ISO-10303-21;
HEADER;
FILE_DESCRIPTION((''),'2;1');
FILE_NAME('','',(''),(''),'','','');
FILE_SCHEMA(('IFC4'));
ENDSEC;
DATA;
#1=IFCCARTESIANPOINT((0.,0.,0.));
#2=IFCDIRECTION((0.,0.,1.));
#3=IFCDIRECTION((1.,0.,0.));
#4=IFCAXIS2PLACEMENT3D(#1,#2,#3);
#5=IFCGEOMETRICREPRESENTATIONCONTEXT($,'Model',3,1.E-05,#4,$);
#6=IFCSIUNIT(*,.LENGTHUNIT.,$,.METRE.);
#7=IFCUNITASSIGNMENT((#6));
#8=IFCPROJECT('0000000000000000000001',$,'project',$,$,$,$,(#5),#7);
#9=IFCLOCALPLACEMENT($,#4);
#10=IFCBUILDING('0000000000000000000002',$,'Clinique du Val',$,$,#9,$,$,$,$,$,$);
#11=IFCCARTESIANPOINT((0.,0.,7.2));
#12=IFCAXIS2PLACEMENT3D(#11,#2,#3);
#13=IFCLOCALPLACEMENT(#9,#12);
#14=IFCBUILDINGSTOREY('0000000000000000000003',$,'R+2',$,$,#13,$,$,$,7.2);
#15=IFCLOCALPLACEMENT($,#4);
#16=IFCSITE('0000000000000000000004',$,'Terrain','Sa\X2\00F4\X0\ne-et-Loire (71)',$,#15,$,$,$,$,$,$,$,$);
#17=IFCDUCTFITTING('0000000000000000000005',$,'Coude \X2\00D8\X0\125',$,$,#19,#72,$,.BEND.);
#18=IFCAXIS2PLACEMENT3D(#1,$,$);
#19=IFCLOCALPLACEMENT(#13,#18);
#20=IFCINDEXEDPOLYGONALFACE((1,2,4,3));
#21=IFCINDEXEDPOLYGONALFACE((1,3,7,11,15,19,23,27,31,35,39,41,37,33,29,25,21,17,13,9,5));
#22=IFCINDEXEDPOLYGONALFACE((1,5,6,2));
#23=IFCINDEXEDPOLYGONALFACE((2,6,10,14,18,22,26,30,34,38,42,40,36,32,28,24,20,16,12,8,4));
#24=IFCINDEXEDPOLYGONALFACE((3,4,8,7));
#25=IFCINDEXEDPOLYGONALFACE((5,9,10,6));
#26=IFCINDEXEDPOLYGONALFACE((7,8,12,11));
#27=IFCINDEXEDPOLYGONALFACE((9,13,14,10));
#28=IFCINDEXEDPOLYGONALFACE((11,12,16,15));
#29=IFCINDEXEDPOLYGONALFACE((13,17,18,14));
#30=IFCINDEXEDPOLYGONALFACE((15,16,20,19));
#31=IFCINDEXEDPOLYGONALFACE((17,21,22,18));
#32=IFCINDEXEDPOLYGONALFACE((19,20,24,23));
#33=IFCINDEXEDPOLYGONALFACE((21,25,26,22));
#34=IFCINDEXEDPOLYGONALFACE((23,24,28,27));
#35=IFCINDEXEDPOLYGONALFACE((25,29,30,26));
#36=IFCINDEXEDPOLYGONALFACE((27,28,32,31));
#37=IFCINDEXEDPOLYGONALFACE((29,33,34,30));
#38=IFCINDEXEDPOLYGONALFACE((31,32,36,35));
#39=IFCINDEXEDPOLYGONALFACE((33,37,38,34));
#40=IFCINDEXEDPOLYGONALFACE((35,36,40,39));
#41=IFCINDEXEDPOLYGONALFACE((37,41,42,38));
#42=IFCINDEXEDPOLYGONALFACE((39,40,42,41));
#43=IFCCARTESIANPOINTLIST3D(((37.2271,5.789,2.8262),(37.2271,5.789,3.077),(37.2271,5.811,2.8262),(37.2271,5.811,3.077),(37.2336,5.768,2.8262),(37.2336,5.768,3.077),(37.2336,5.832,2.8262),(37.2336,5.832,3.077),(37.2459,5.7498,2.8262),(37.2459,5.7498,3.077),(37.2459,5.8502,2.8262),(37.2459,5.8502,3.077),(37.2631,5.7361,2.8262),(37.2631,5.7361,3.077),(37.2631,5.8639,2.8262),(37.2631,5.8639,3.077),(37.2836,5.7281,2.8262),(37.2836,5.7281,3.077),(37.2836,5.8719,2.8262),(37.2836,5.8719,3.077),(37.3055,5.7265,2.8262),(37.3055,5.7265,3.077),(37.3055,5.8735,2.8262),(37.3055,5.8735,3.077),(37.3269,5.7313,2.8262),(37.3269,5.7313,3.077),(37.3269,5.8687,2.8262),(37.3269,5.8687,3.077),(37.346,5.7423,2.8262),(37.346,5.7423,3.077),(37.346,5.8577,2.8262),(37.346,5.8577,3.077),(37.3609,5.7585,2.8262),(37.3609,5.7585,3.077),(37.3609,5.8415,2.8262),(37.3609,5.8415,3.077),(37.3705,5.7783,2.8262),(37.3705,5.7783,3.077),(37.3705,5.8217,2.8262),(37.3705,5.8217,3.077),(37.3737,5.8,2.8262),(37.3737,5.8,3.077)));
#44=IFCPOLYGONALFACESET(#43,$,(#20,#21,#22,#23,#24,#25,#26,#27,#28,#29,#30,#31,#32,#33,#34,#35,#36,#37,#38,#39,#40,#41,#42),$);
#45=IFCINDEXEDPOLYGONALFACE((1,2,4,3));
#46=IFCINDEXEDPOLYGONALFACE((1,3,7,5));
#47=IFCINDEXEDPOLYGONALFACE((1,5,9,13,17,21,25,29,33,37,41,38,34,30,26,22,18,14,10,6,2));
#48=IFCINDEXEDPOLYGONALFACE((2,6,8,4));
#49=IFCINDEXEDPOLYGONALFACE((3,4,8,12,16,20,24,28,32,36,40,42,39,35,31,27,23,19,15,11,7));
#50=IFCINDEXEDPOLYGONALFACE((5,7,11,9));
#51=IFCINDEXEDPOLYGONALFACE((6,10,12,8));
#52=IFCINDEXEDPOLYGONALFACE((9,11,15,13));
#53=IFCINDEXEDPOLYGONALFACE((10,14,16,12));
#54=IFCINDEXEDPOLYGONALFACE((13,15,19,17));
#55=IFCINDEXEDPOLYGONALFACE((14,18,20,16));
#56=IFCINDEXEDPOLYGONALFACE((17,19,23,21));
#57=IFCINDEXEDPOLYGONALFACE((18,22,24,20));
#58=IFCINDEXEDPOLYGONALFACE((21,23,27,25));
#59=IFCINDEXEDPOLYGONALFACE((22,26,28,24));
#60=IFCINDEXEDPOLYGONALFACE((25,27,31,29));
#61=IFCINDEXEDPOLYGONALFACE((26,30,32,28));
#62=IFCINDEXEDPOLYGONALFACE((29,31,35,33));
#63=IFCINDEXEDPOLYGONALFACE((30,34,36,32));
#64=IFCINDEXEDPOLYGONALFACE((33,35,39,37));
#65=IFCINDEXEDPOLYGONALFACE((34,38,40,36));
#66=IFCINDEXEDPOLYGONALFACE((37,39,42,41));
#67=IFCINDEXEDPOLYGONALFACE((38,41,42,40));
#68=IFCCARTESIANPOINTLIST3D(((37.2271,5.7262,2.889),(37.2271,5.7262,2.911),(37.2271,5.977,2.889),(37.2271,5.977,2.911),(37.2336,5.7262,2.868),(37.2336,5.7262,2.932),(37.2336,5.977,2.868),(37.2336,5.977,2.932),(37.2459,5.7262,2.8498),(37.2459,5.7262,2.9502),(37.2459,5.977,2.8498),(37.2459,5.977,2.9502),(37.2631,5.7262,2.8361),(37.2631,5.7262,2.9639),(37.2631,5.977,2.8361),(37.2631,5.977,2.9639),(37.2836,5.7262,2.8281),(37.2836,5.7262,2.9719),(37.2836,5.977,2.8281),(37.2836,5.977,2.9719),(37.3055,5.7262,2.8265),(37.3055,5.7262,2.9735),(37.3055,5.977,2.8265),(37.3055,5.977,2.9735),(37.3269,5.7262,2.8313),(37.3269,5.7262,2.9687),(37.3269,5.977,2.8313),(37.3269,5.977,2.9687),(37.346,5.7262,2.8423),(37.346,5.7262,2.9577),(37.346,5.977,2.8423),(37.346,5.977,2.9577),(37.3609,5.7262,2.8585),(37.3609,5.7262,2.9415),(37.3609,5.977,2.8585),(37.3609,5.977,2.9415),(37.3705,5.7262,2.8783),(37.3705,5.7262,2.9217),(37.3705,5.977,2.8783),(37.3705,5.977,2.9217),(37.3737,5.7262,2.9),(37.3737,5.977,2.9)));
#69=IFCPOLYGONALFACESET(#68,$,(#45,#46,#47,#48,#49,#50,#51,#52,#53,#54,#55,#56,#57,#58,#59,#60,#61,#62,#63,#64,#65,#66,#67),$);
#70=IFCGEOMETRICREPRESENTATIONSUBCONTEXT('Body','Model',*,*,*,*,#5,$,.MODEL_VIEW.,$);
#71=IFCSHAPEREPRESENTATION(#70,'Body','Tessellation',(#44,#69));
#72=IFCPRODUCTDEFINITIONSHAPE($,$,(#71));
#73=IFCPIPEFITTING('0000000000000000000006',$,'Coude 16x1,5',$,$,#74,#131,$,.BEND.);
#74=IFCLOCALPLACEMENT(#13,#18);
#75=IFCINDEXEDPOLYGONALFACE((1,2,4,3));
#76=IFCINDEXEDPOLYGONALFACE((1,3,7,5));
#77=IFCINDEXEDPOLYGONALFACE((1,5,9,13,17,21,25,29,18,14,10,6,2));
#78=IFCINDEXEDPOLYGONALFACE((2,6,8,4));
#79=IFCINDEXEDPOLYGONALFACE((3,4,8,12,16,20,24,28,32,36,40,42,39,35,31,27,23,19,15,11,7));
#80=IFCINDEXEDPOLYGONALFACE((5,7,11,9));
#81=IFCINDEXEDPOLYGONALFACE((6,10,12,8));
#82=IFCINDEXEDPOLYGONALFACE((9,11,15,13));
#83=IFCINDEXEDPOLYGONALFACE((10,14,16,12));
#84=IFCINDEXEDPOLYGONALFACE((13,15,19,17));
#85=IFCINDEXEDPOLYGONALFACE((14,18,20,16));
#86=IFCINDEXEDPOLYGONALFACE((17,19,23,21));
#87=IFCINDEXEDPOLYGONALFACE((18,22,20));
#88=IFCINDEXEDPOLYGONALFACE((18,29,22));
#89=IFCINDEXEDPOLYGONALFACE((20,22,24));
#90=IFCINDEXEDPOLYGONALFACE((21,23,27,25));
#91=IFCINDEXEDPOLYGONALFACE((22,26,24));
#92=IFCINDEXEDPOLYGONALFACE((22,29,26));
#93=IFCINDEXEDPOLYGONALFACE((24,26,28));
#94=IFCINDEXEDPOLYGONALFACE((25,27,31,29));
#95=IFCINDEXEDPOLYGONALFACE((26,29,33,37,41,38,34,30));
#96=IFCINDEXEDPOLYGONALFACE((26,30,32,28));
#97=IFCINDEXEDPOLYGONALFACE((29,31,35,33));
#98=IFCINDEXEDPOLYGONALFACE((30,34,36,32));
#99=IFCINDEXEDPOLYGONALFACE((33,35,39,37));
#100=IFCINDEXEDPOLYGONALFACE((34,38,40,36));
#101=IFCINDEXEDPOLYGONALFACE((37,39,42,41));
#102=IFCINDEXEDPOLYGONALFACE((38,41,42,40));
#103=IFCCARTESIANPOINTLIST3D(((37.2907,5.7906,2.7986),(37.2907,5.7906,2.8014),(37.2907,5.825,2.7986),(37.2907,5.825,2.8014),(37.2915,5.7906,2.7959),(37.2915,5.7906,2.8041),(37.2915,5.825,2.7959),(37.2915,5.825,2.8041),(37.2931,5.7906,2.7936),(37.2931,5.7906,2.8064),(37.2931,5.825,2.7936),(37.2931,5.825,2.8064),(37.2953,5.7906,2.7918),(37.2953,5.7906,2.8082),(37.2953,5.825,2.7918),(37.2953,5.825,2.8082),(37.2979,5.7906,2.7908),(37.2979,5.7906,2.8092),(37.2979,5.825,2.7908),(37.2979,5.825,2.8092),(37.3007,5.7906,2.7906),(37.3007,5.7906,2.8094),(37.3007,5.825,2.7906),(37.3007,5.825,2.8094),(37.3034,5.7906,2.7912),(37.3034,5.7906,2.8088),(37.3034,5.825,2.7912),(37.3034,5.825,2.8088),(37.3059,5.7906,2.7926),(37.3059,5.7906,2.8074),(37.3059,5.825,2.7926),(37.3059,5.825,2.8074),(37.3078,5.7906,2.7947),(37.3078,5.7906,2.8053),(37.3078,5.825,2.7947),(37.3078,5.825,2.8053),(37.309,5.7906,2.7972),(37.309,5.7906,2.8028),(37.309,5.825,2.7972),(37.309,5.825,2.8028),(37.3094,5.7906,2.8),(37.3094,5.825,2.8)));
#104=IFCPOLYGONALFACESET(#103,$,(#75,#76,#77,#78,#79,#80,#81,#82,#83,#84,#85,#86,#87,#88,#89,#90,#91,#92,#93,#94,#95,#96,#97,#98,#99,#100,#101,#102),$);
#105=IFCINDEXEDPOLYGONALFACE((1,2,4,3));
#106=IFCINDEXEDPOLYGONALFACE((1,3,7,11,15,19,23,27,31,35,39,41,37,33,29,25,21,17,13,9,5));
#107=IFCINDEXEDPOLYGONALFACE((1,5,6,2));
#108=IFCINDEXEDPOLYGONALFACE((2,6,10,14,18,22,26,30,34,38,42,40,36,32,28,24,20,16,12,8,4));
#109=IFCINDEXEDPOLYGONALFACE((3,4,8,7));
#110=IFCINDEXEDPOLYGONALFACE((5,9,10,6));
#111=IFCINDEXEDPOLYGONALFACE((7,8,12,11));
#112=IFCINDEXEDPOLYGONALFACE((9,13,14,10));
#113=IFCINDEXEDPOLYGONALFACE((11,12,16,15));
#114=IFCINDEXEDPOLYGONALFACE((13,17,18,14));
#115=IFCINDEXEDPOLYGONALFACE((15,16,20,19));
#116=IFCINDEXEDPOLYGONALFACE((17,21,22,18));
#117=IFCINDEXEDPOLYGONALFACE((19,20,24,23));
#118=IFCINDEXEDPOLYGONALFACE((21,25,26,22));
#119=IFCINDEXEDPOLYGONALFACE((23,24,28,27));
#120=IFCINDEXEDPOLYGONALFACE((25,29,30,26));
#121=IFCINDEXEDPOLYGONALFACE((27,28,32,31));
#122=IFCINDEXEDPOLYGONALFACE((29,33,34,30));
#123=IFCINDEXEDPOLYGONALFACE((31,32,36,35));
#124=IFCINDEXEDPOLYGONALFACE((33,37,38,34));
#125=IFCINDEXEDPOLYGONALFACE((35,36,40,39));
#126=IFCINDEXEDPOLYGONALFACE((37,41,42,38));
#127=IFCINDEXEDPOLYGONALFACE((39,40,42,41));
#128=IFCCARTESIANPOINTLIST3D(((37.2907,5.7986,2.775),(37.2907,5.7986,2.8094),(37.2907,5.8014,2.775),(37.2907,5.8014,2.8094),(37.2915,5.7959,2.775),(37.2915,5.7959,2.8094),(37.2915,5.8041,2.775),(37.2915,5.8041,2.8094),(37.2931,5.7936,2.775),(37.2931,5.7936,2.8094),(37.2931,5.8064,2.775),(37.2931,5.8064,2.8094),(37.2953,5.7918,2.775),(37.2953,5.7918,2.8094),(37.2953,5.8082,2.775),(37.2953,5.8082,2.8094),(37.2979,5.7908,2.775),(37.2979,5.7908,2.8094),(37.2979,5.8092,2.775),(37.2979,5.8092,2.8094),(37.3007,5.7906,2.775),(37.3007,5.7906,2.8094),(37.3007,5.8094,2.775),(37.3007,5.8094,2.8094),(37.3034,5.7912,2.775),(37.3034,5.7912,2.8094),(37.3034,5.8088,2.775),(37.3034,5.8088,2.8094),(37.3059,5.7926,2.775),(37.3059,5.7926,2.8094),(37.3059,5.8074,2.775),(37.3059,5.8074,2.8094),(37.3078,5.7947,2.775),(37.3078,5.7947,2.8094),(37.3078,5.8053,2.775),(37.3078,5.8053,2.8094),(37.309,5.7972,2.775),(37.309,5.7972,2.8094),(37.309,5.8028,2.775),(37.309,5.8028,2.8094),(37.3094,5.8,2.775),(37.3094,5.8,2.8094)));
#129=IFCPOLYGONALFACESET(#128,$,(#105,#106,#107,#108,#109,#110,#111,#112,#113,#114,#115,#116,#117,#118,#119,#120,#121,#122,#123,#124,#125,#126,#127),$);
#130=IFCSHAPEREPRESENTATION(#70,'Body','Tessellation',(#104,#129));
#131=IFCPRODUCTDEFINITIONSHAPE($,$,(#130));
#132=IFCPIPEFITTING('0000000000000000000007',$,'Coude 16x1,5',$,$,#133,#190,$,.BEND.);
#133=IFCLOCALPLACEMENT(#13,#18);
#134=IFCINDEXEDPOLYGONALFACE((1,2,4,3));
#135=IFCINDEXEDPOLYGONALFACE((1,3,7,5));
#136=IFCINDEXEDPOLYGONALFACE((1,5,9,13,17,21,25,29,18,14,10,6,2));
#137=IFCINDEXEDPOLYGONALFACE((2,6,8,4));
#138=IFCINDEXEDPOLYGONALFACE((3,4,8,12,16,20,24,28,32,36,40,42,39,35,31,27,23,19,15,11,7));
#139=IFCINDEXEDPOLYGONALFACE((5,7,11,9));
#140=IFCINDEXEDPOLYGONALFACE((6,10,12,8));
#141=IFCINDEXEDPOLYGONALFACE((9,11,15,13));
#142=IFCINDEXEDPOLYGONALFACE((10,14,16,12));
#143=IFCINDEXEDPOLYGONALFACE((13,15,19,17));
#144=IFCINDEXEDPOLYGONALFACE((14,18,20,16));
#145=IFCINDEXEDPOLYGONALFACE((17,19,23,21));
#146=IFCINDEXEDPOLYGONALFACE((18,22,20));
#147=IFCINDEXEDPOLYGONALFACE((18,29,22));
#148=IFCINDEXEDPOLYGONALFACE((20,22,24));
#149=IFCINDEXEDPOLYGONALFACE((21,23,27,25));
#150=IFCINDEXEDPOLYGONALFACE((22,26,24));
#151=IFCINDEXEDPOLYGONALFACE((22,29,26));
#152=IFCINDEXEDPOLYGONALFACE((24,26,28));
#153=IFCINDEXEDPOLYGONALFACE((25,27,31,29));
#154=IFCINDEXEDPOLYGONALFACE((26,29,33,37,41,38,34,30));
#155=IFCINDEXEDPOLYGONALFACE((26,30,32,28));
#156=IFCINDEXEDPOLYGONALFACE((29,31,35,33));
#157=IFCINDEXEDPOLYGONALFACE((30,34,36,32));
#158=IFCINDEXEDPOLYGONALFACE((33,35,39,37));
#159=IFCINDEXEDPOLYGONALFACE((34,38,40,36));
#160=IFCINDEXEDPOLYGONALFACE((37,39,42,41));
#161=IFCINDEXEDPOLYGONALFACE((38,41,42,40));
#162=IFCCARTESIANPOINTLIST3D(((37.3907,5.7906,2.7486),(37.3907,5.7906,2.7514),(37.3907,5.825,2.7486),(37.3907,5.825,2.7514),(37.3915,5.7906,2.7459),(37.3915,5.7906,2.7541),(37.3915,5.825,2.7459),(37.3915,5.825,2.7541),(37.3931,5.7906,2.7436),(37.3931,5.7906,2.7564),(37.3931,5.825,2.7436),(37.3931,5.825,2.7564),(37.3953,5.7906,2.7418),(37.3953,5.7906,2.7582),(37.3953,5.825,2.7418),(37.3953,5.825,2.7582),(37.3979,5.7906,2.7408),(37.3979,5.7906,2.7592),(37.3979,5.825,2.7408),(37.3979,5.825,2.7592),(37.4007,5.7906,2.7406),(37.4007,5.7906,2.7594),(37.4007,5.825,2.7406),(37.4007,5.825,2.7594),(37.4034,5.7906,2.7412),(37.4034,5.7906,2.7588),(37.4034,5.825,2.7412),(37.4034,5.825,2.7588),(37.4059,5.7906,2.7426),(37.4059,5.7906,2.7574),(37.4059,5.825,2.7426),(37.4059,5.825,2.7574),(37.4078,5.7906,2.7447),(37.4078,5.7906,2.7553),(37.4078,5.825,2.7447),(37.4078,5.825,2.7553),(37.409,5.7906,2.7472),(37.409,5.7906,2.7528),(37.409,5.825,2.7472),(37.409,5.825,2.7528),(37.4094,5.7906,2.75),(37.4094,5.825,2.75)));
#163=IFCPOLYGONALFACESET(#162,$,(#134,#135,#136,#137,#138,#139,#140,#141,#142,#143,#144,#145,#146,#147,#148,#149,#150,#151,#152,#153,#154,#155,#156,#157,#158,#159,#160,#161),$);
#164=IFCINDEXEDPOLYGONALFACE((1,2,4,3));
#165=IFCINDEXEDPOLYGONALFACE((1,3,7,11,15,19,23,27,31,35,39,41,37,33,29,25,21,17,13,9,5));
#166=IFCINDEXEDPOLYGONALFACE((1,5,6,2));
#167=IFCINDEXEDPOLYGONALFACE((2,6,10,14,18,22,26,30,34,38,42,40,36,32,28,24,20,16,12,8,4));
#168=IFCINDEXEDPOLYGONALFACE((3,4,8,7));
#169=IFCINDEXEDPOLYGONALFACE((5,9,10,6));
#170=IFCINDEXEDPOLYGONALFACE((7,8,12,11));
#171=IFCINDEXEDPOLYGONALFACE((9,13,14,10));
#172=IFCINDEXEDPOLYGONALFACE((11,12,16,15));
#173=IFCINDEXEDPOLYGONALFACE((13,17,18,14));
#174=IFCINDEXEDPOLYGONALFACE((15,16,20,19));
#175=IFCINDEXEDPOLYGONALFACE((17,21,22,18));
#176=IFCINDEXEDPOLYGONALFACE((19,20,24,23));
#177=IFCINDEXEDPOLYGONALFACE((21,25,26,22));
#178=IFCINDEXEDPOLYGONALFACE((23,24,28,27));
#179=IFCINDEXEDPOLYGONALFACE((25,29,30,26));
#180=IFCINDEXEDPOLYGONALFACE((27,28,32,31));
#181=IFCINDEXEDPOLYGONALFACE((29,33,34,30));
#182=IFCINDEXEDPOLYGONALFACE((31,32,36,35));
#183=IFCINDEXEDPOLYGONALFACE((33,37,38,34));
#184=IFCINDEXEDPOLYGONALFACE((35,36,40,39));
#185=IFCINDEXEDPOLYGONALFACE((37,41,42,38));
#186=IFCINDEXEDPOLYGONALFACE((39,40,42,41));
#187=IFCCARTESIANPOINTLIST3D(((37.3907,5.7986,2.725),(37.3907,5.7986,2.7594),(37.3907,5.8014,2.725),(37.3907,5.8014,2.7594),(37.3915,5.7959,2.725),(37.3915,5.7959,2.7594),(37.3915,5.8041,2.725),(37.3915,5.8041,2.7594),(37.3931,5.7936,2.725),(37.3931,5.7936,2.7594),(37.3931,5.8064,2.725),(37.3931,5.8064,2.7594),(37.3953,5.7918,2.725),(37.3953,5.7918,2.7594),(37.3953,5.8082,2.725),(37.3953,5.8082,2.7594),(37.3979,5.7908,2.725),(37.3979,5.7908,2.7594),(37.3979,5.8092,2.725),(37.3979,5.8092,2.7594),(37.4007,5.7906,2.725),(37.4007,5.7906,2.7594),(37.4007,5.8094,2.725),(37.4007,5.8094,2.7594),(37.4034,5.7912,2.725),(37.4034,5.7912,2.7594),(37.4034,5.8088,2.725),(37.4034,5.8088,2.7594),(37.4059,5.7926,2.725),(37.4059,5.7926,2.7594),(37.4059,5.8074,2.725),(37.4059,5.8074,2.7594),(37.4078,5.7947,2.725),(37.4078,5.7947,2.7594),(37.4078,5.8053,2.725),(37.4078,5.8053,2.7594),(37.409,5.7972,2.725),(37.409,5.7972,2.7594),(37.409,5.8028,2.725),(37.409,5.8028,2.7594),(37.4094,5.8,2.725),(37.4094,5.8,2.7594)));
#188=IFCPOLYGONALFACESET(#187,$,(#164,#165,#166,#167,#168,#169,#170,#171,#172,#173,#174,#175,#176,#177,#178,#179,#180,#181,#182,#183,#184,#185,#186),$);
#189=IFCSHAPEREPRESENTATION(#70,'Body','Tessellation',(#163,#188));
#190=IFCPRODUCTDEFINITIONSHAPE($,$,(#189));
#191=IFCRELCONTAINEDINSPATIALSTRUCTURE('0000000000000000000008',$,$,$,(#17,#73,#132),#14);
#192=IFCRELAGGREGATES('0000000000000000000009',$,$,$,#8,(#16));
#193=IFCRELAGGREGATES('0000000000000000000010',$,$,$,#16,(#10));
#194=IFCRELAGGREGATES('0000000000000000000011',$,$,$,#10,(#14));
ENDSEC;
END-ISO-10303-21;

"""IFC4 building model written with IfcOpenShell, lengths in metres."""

from ifc_helpers import new_model, si_unit, frame, origin_with_axes, place, context, subcontext, project, spatial, circle, extrude, element, save


model = new_model("IFC4")

# Units and contexts
model_context = context("Model", 3, precision=1e-05, world=origin_with_axes())
body_context = subcontext(model_context, "Body", "Model", "MODEL_VIEW")
ifc_project = project(units=[si_unit("LENGTHUNIT", "METRE")], contexts=[model_context])

# Site, building, storey
site_placement = place(None, origin_with_axes())
site = spatial("IfcSite", under=ifc_project, at=site_placement, Name="Terrain", Description="Saône-et-Loire (71)")
building_placement = place(None, origin_with_axes())
building = spatial("IfcBuilding", under=site, at=building_placement, Name="Clinique du Val")
storey_placement = place(building_placement, frame((0.0, 0.0, 7.2), z_axis=(0.0, 0.0, 1.0), x_axis=(1.0, 0.0, 0.0)))
storey = spatial("IfcBuildingStorey", under=building, at=storey_placement, Name="R+2", Elevation=7.2)

# Duct fitting
duct_fitting_1_placement = place(storey_placement, frame((37.3, 5.8, 2.9), z_axis=(0.0, 0.0, 1.0), x_axis=(1.0, 0.0, 0.0)))
element("IfcDuctFitting", 1, at=duct_fitting_1_placement, inside=storey, Name="Coude Ø125", PredefinedType="BEND", context=body_context, shape_type="SweptSolid", body=[
    extrude(circle(Radius=0.0737), frame((0.0, 0.0, -0.0737), z_axis=(0.0, 0.0, 1.0), x_axis=(1.0, 0.0, 0.0)), (0.0, 0.0, 1.0), 0.2507),
    extrude(circle(Radius=0.0737), frame((0.0, -0.0737, 0.0), z_axis=(0.0, 1.0, 0.0), x_axis=(1.0, 0.0, 0.0)), (0.0, 0.0, 1.0), 0.2507),
])

# Pipe fittings
for number, where, z_axis, x_axis, name in (
    (2, (37.3, 5.8, 2.8), (0.0, 0.0, 1.0), (1.0, 0.0, 0.0), "Coude 16x1,5"),
    (3, (37.4, 5.8, 2.75), (0.0, 0.0, 1.0), (1.0, 0.0, 0.0), "Coude 16x1,5"),
):
    element("IfcPipeFitting", number, at=place(storey_placement, frame(where, z_axis=z_axis, x_axis=x_axis)), inside=storey, Name=name, PredefinedType="BEND", context=body_context, shape_type="SweptSolid", body=[
        extrude(circle(Radius=0.0094), frame((0.0, -0.0094, 0.0), z_axis=(0.0, 1.0, 0.0), x_axis=(1.0, 0.0, 0.0)), (0.0, 0.0, 1.0), 0.0344),
        extrude(circle(Radius=0.0094), frame((0.0, 0.0, 0.0094), z_axis=(0.0, 0.0, -1.0), x_axis=(1.0, 0.0, 0.0)), (0.0, 0.0, 1.0), 0.0344),
    ])

save(model, "model.ifc")
